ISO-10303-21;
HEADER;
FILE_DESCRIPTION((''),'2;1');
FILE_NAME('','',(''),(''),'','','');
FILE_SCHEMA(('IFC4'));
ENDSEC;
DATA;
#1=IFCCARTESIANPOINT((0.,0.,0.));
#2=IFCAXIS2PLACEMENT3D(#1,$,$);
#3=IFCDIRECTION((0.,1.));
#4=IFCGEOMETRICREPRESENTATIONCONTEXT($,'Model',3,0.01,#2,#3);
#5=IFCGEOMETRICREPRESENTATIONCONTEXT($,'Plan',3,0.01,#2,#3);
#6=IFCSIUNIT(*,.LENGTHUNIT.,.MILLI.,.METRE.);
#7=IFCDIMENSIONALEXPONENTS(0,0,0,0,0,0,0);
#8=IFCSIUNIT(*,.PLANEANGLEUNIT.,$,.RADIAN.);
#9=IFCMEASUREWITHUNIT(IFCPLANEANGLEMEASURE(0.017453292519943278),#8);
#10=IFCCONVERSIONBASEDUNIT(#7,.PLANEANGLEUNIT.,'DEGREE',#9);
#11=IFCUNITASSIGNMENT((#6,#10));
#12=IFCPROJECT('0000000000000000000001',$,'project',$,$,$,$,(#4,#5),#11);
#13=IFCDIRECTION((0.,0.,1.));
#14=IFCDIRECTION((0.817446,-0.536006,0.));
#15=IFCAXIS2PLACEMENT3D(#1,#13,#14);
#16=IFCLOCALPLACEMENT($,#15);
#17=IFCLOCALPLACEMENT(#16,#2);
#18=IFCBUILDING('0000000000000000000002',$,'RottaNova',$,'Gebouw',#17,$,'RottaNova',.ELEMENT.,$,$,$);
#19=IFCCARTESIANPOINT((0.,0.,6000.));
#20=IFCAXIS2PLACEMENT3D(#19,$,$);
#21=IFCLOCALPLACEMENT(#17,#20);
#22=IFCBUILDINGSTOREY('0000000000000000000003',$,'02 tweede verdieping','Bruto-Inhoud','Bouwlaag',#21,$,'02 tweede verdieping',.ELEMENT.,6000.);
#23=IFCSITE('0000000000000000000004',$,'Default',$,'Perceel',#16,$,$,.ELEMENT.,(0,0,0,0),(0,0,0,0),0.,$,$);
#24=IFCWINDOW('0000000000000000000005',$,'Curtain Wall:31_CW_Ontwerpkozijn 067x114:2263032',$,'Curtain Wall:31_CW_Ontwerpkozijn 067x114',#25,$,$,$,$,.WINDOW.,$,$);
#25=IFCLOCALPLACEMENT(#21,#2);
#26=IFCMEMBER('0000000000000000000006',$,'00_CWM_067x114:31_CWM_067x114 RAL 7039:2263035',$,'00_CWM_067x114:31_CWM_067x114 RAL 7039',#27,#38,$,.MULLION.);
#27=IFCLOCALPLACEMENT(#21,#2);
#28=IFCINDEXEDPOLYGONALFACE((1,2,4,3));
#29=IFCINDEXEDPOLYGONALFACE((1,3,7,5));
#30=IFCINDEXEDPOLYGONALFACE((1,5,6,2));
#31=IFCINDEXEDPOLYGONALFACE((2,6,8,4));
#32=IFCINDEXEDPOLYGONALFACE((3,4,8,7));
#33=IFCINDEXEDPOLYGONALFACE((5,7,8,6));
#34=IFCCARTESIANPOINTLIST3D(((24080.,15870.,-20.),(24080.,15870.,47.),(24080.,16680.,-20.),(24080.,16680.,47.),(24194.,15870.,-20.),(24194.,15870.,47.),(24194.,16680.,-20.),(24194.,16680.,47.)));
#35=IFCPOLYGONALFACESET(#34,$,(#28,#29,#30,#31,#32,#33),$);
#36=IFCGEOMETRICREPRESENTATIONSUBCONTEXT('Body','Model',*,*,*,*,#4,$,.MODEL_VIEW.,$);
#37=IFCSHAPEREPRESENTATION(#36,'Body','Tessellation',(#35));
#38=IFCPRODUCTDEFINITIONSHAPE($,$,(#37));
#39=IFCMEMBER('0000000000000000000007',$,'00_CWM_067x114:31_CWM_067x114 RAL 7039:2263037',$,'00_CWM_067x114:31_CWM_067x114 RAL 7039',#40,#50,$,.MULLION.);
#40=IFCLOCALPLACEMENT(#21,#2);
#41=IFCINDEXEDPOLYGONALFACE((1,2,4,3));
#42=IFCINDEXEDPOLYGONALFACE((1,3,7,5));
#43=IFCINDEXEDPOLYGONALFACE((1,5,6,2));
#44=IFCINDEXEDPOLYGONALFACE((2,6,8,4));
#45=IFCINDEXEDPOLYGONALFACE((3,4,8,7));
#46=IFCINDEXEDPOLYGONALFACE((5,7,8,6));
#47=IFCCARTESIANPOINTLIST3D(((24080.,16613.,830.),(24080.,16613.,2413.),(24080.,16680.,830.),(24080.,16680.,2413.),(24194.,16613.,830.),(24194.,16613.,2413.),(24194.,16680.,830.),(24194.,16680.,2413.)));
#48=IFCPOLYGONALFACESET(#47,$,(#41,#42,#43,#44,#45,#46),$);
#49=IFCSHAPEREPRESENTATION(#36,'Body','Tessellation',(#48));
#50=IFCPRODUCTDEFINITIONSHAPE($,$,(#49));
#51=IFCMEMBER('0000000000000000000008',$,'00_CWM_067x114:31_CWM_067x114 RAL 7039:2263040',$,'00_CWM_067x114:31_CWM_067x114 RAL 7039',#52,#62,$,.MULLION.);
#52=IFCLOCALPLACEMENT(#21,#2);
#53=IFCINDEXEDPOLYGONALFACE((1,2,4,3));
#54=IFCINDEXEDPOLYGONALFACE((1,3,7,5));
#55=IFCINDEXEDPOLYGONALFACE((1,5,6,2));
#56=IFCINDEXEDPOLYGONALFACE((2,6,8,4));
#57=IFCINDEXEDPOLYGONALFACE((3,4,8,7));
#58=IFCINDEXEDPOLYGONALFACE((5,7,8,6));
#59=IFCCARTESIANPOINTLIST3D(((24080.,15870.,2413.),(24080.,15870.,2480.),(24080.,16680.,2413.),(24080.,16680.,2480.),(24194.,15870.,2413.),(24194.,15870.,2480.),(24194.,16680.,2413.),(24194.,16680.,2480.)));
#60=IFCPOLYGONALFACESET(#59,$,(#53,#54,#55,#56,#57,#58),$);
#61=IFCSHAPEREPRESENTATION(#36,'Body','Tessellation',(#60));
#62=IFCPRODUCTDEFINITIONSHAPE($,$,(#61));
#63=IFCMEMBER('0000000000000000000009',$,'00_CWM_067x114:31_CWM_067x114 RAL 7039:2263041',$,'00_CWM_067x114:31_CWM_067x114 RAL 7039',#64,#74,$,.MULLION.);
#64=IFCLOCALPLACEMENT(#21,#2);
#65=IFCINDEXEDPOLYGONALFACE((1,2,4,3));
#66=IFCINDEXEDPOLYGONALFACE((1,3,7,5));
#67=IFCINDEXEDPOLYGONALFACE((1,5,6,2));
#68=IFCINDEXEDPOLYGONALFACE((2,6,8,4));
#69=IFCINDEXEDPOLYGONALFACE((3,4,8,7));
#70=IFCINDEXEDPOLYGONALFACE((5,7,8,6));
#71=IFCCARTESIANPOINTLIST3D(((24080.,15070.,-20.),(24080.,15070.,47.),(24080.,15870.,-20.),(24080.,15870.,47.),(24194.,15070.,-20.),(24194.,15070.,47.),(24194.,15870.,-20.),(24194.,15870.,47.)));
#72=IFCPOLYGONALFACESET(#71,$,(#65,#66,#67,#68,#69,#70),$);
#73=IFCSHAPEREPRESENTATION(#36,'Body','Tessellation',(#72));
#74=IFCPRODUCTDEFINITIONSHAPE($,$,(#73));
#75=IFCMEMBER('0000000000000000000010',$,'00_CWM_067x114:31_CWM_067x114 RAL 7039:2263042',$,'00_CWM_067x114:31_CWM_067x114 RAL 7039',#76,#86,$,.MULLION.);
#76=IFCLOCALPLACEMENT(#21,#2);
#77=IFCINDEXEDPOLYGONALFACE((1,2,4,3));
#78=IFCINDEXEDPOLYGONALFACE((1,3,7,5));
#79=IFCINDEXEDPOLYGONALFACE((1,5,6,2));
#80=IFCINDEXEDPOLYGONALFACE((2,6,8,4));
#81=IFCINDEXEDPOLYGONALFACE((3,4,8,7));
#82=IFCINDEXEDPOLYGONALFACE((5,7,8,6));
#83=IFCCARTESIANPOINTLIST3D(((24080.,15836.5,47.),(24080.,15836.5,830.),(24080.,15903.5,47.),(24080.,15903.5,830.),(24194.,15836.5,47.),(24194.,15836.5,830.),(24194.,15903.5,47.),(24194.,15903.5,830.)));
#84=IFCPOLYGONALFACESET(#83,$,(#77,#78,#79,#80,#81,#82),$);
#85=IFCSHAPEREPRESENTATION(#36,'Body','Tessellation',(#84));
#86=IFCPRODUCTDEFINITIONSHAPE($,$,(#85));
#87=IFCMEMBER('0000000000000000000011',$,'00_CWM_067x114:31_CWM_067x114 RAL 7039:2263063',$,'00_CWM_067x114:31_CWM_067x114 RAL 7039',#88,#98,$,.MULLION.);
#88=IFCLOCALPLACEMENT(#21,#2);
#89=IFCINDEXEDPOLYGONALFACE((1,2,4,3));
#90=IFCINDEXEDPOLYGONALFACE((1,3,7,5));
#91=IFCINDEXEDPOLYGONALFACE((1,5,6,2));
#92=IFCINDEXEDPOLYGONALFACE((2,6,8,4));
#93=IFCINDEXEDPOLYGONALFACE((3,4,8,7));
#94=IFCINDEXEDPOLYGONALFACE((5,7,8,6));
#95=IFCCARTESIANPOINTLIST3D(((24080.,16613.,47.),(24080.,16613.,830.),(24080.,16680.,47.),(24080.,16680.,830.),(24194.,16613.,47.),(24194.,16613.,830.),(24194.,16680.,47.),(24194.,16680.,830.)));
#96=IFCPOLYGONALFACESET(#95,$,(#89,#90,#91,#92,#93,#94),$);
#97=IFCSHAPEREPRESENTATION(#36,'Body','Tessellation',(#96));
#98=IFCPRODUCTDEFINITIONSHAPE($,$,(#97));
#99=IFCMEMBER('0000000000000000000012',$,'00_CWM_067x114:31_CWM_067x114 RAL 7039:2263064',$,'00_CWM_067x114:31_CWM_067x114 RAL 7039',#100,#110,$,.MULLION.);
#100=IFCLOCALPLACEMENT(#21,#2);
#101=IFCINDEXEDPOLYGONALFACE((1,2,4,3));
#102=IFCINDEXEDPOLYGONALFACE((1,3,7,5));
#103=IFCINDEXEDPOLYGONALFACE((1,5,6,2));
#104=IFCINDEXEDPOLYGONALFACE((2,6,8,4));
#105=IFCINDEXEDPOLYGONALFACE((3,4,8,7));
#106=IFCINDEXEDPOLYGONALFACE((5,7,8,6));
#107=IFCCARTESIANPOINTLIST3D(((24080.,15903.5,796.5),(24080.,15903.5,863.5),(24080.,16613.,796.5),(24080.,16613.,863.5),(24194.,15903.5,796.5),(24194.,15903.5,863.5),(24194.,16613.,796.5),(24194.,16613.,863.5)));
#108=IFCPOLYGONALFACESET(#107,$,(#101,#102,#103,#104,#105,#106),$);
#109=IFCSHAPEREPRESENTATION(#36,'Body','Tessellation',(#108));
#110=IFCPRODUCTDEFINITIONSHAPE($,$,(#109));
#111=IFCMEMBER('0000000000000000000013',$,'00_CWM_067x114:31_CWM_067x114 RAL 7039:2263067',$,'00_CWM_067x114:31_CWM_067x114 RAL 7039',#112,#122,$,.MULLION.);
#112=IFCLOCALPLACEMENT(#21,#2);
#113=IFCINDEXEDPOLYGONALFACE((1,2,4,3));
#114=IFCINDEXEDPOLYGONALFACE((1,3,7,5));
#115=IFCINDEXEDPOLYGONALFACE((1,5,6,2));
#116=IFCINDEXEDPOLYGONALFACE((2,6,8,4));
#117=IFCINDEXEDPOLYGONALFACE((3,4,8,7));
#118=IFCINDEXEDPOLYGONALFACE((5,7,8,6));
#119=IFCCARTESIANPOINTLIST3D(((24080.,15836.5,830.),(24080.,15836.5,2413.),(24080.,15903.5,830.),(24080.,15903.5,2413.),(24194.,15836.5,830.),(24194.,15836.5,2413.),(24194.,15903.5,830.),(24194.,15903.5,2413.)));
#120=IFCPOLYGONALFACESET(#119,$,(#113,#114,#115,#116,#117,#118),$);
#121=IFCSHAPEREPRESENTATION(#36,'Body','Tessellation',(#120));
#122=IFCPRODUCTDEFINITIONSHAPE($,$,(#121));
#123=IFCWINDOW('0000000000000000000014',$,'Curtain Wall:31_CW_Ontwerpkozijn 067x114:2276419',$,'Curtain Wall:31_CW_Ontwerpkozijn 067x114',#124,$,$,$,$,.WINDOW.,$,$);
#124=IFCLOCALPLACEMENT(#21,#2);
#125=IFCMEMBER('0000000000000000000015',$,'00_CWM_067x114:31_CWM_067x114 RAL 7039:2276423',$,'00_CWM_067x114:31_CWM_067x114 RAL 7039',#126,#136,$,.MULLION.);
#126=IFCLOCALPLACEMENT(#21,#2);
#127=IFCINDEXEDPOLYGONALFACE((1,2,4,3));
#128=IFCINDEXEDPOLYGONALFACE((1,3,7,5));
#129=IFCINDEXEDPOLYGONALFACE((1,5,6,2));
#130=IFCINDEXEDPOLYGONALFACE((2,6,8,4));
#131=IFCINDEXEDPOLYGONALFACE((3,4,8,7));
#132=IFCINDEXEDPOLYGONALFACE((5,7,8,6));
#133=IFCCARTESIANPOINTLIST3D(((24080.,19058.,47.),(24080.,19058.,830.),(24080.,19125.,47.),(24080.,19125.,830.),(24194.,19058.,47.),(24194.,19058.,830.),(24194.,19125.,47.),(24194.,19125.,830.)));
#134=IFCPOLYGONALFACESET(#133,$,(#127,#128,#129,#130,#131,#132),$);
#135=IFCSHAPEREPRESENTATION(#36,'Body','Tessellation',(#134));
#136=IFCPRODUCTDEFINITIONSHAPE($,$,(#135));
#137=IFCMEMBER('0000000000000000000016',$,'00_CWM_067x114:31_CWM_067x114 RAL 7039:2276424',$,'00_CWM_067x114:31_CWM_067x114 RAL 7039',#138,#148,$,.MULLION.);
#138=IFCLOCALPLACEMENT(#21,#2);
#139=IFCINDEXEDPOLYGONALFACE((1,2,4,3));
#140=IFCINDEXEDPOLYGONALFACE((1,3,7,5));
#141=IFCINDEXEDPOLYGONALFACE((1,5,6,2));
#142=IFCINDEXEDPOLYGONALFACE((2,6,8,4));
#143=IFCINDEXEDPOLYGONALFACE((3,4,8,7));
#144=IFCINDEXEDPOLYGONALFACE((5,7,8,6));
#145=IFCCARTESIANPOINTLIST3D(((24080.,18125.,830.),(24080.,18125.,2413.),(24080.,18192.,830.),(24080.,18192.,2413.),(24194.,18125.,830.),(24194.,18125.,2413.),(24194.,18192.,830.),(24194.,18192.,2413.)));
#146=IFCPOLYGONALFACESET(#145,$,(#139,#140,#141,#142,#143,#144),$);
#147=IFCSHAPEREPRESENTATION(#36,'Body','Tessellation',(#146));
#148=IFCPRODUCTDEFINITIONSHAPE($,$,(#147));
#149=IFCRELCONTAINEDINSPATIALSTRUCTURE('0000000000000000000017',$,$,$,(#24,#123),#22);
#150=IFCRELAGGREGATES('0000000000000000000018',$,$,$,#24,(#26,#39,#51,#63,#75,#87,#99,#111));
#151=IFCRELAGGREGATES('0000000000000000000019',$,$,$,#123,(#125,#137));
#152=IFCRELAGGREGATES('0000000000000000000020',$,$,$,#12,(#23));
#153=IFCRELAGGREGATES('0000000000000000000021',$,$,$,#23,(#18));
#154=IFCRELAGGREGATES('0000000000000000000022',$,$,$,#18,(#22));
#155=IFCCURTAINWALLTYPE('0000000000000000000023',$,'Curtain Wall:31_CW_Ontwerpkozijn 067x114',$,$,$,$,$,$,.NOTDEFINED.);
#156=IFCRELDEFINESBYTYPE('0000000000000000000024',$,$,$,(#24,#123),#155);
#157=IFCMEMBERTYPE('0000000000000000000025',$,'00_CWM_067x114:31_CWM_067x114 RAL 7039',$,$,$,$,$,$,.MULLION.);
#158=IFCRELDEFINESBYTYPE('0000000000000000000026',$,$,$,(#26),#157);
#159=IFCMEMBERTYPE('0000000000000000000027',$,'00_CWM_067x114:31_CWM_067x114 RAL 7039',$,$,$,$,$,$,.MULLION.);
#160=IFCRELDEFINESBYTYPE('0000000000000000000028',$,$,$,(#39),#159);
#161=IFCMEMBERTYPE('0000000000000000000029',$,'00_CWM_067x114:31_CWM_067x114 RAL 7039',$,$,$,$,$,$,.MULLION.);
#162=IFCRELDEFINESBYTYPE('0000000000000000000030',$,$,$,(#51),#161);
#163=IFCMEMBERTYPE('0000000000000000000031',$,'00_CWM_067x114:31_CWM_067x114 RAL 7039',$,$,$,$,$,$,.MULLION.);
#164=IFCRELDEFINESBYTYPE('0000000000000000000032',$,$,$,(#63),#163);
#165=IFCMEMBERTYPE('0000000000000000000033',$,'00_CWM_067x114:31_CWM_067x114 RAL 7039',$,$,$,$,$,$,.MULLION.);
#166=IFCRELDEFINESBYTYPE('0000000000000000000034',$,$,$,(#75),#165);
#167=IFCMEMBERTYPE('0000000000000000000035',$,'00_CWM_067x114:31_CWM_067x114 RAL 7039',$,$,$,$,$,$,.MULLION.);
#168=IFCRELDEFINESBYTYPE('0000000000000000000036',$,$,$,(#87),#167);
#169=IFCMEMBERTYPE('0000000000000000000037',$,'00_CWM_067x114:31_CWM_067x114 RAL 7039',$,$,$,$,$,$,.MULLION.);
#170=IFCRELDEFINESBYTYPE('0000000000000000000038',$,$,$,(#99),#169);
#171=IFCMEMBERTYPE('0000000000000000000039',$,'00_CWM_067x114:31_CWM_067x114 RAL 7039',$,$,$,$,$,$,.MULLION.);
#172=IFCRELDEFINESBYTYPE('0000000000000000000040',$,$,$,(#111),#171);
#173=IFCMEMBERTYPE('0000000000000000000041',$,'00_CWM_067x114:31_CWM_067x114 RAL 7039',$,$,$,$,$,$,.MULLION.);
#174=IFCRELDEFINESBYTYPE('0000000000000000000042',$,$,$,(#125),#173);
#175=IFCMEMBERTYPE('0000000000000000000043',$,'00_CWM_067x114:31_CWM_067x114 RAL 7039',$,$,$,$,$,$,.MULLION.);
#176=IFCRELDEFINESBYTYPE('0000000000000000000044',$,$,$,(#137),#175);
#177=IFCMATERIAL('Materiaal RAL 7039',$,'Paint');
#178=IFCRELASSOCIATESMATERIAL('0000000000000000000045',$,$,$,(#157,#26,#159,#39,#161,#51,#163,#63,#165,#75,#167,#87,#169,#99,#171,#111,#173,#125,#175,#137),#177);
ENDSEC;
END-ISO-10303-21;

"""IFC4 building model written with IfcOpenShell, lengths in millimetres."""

from ifc_helpers import new_model, entity, si_unit, converted_unit, direction, frame, origin, place, context, subcontext, project, spatial, indexed_curve, outline, extrude, source, transform, mapped, material, type_object, type_shapes, element, aggregate, save


model = new_model("IFC4")

# Units and contexts
model_context = context("Model", 3, precision=0.01, world=origin(), true_north=direction((0.0, 1.0)))
plan_context = context("Plan", 3, precision=0.01, world=origin(), true_north=direction((0.0, 1.0)))
body_context = subcontext(model_context, "Body", "Model", "MODEL_VIEW")
ifc_project = project(units=[si_unit("LENGTHUNIT", "METRE", prefix="MILLI"), converted_unit("PLANEANGLEUNIT", "DEGREE", entity("IfcPlaneAngleMeasure", 0.017453292519943278), si_unit("PLANEANGLEUNIT", "RADIAN"), dimensions=[0, 0, 0, 0, 0, 0, 0])], contexts=[model_context, plan_context])

# Site, building, storey
site_placement = place(None, frame((0.0, 0.0, 0.0), z_axis=(0.0, 0.0, 1.0), x_axis=(0.817446, -0.536006, 0.0)))
site = spatial("IfcSite", under=ifc_project, at=site_placement, Name="Default", ObjectType="Perceel", CompositionType="ELEMENT", RefLatitude=(0, 0, 0, 0), RefLongitude=(0, 0, 0, 0), RefElevation=0.0)
building_placement = place(site_placement, origin())
building = spatial("IfcBuilding", under=site, at=building_placement, Name="RottaNova", ObjectType="Gebouw", LongName="RottaNova", CompositionType="ELEMENT")
storey_placement = place(building_placement, frame((0.0, 0.0, 6000.0)))
storey = spatial("IfcBuildingStorey", under=building, at=storey_placement, Name="02 tweede verdieping", Description="Bruto-Inhoud", ObjectType="Bouwlaag", LongName="02 tweede verdieping", CompositionType="ELEMENT", Elevation=6000.0)

# Windows, members
curtain_wall_type = type_object("IfcCurtainWallType", Name="Curtain Wall:31_CW_Ontwerpkozijn 067x114", PredefinedType="NOTDEFINED")
window_1_placement = place(storey_placement, frame((0.0, 0.0, -6000.0)))
window_1 = element("IfcWindow", 1, at=window_1_placement, inside=storey, type_object=curtain_wall_type, Name="Curtain Wall:31_CW_Ontwerpkozijn 067x114:2263032", ObjectType="Curtain Wall:31_CW_Ontwerpkozijn 067x114", PredefinedType="WINDOW")
ifc_material_1 = material(Name="Materiaal RAL 7039", Category="Paint")
member_type_1 = type_object("IfcMemberType", Name="00_CWM_067x114:31_CWM_067x114 RAL 7039", PredefinedType="MULLION", material=ifc_material_1)
shared_shape_1 = source(origin(), body_context, "Body", "SweptSolid", [
    extrude(outline(indexed_curve([(-33.5, -57.0), (33.5, -57.0), (33.5, 57.0), (-33.5, 57.0), (-33.5, -57.0)], self_intersect=False)), frame((-33.5, -57.0, -810.0), z_axis=(0.0, 0.0, 1.0), x_axis=(-1.0, 0.0, 0.0)), (0.0, 0.0, 1.0), 810.0),
])
type_shapes(member_type_1, [shared_shape_1])
member_1_placement = place(window_1_placement, frame((24080.0, 16680.0, 5980.0), z_axis=(0.0, 1.0, 0.0), x_axis=(0.0, 0.0, -1.0)))
member_1 = element("IfcMember", 2, at=member_1_placement, type_object=member_type_1, material=ifc_material_1, Name="00_CWM_067x114:31_CWM_067x114 RAL 7039:2263035", ObjectType="00_CWM_067x114:31_CWM_067x114 RAL 7039", PredefinedType="MULLION", context=body_context, shape_type="MappedRepresentation", body=[
    mapped(shared_shape_1, transform((0.0, 0.0, 0.0), scale=1.0)),
])
member_type_2 = type_object("IfcMemberType", Name="00_CWM_067x114:31_CWM_067x114 RAL 7039", PredefinedType="MULLION", material=ifc_material_1)
shared_shape_2 = source(origin(), body_context, "Body", "SweptSolid", [
    extrude(outline(indexed_curve([(-33.5, -57.0), (33.5, -57.0), (33.5, 57.0), (-33.5, 57.0), (-33.5, -57.0)], self_intersect=False)), frame((-33.5, -57.0, -1583.0), z_axis=(0.0, 0.0, 1.0), x_axis=(-1.0, 0.0, 0.0)), (0.0, 0.0, 1.0), 1583.0),
])
type_shapes(member_type_2, [shared_shape_2])
member_2_placement = place(window_1_placement, frame((24080.0, 16680.0, 8413.0), z_axis=(0.0, 0.0, 1.0), x_axis=(0.0, 1.0, 0.0)))
member_2 = element("IfcMember", 3, at=member_2_placement, type_object=member_type_2, material=ifc_material_1, Name="00_CWM_067x114:31_CWM_067x114 RAL 7039:2263037", ObjectType="00_CWM_067x114:31_CWM_067x114 RAL 7039", PredefinedType="MULLION", context=body_context, shape_type="MappedRepresentation", body=[
    mapped(shared_shape_2, transform((0.0, 0.0, 0.0), scale=1.0)),
])
member_type_3 = type_object("IfcMemberType", Name="00_CWM_067x114:31_CWM_067x114 RAL 7039", PredefinedType="MULLION", material=ifc_material_1)
shared_shape_3 = source(origin(), body_context, "Body", "SweptSolid", [
    extrude(outline(indexed_curve([(-33.5, -57.0), (33.5, -57.0), (33.5, 57.0), (-33.5, 57.0), (-33.5, -57.0)], self_intersect=False)), frame((-33.5, -57.0, -810.0), z_axis=(0.0, 0.0, 1.0), x_axis=(-1.0, 0.0, 0.0)), (0.0, 0.0, 1.0), 810.0),
])
type_shapes(member_type_3, [shared_shape_3])
member_3_placement = place(window_1_placement, frame((24080.0, 15870.0, 8480.0), z_axis=(0.0, -1.0, 0.0), x_axis=(0.0, 0.0, 1.0)))
member_3 = element("IfcMember", 4, at=member_3_placement, type_object=member_type_3, material=ifc_material_1, Name="00_CWM_067x114:31_CWM_067x114 RAL 7039:2263040", ObjectType="00_CWM_067x114:31_CWM_067x114 RAL 7039", PredefinedType="MULLION", context=body_context, shape_type="MappedRepresentation", body=[
    mapped(shared_shape_3, transform((0.0, 0.0, 0.0), scale=1.0)),
])
member_type_4 = type_object("IfcMemberType", Name="00_CWM_067x114:31_CWM_067x114 RAL 7039", PredefinedType="MULLION", material=ifc_material_1)
shared_shape_4 = source(origin(), body_context, "Body", "SweptSolid", [
    extrude(outline(indexed_curve([(-33.5, -57.0), (33.5, -57.0), (33.5, 57.0), (-33.5, 57.0), (-33.5, -57.0)], self_intersect=False)), frame((-33.5, -57.0, -800.0), z_axis=(0.0, 0.0, 1.0), x_axis=(-1.0, 0.0, 0.0)), (0.0, 0.0, 1.0), 800.0),
])
type_shapes(member_type_4, [shared_shape_4])
member_4_placement = place(window_1_placement, frame((24080.0, 15870.0, 5980.0), z_axis=(0.0, 1.0, 0.0), x_axis=(0.0, 0.0, -1.0)))
member_4 = element("IfcMember", 5, at=member_4_placement, type_object=member_type_4, material=ifc_material_1, Name="00_CWM_067x114:31_CWM_067x114 RAL 7039:2263041", ObjectType="00_CWM_067x114:31_CWM_067x114 RAL 7039", PredefinedType="MULLION", context=body_context, shape_type="MappedRepresentation", body=[
    mapped(shared_shape_4, transform((0.0, 0.0, 0.0), scale=1.0)),
])
member_type_5 = type_object("IfcMemberType", Name="00_CWM_067x114:31_CWM_067x114 RAL 7039", PredefinedType="MULLION", material=ifc_material_1)
shared_shape_5 = source(origin(), body_context, "Body", "SweptSolid", [
    extrude(outline(indexed_curve([(-33.5, -57.0), (33.5, -57.0), (33.5, 57.0), (-33.5, 57.0), (-33.5, -57.0)], self_intersect=False)), frame((0.0, -57.0, -783.0), z_axis=(0.0, 0.0, 1.0), x_axis=(-1.0, 0.0, 0.0)), (0.0, 0.0, 1.0), 783.0),
])
type_shapes(member_type_5, [shared_shape_5])
member_5_placement = place(window_1_placement, frame((24080.0, 15870.0, 6047.0), z_axis=(0.0, 0.0, -1.0), x_axis=(0.0, -1.0, 0.0)))
member_5 = element("IfcMember", 6, at=member_5_placement, type_object=member_type_5, material=ifc_material_1, Name="00_CWM_067x114:31_CWM_067x114 RAL 7039:2263042", ObjectType="00_CWM_067x114:31_CWM_067x114 RAL 7039", PredefinedType="MULLION", context=body_context, shape_type="MappedRepresentation", body=[
    mapped(shared_shape_5, transform((0.0, 0.0, 0.0), scale=1.0)),
])
member_type_6 = type_object("IfcMemberType", Name="00_CWM_067x114:31_CWM_067x114 RAL 7039", PredefinedType="MULLION", material=ifc_material_1)
shared_shape_6 = source(origin(), body_context, "Body", "SweptSolid", [
    extrude(outline(indexed_curve([(-33.5, -57.0), (33.5, -57.0), (33.5, 57.0), (-33.5, 57.0), (-33.5, -57.0)], self_intersect=False)), frame((-33.5, -57.0, -783.0), z_axis=(0.0, 0.0, 1.0), x_axis=(-1.0, 0.0, 0.0)), (0.0, 0.0, 1.0), 783.0),
])
type_shapes(member_type_6, [shared_shape_6])
member_6_placement = place(window_1_placement, frame((24080.0, 16680.0, 6830.0), z_axis=(0.0, 0.0, 1.0), x_axis=(0.0, 1.0, 0.0)))
member_6 = element("IfcMember", 7, at=member_6_placement, type_object=member_type_6, material=ifc_material_1, Name="00_CWM_067x114:31_CWM_067x114 RAL 7039:2263063", ObjectType="00_CWM_067x114:31_CWM_067x114 RAL 7039", PredefinedType="MULLION", context=body_context, shape_type="MappedRepresentation", body=[
    mapped(shared_shape_6, transform((0.0, 0.0, 0.0), scale=1.0)),
])
member_type_7 = type_object("IfcMemberType", Name="00_CWM_067x114:31_CWM_067x114 RAL 7039", PredefinedType="MULLION", material=ifc_material_1)
shared_shape_7 = source(origin(), body_context, "Body", "SweptSolid", [
    extrude(outline(indexed_curve([(-33.5, -57.0), (33.5, -57.0), (33.5, 57.0), (-33.5, 57.0), (-33.5, -57.0)], self_intersect=False)), frame((0.0, -57.0, -709.5), z_axis=(0.0, 0.0, 1.0), x_axis=(-1.0, 0.0, 0.0)), (0.0, 0.0, 1.0), 709.5),
])
type_shapes(member_type_7, [shared_shape_7])
member_7_placement = place(window_1_placement, frame((24080.0, 15903.5, 6830.0), z_axis=(0.0, -1.0, 0.0), x_axis=(0.0, 0.0, 1.0)))
member_7 = element("IfcMember", 8, at=member_7_placement, type_object=member_type_7, material=ifc_material_1, Name="00_CWM_067x114:31_CWM_067x114 RAL 7039:2263064", ObjectType="00_CWM_067x114:31_CWM_067x114 RAL 7039", PredefinedType="MULLION", context=body_context, shape_type="MappedRepresentation", body=[
    mapped(shared_shape_7, transform((0.0, 0.0, 0.0), scale=1.0)),
])
member_type_8 = type_object("IfcMemberType", Name="00_CWM_067x114:31_CWM_067x114 RAL 7039", PredefinedType="MULLION", material=ifc_material_1)
shared_shape_8 = source(origin(), body_context, "Body", "SweptSolid", [
    extrude(outline(indexed_curve([(-33.5, -57.0), (33.5, -57.0), (33.5, 57.0), (-33.5, 57.0), (-33.5, -57.0)], self_intersect=False)), frame((0.0, -57.0, -1583.0), z_axis=(0.0, 0.0, 1.0), x_axis=(-1.0, 0.0, 0.0)), (0.0, 0.0, 1.0), 1583.0),
])
type_shapes(member_type_8, [shared_shape_8])
member_8_placement = place(window_1_placement, frame((24080.0, 15870.0, 6830.0), z_axis=(0.0, 0.0, -1.0), x_axis=(0.0, -1.0, 0.0)))
member_8 = element("IfcMember", 9, at=member_8_placement, type_object=member_type_8, material=ifc_material_1, Name="00_CWM_067x114:31_CWM_067x114 RAL 7039:2263067", ObjectType="00_CWM_067x114:31_CWM_067x114 RAL 7039", PredefinedType="MULLION", context=body_context, shape_type="MappedRepresentation", body=[
    mapped(shared_shape_8, transform((0.0, 0.0, 0.0), scale=1.0)),
])
window_2_placement = place(storey_placement, frame((0.0, 0.0, -6000.0)))
window_2 = element("IfcWindow", 10, at=window_2_placement, inside=storey, type_object=curtain_wall_type, Name="Curtain Wall:31_CW_Ontwerpkozijn 067x114:2276419", ObjectType="Curtain Wall:31_CW_Ontwerpkozijn 067x114", PredefinedType="WINDOW")
member_type_9 = type_object("IfcMemberType", Name="00_CWM_067x114:31_CWM_067x114 RAL 7039", PredefinedType="MULLION", material=ifc_material_1)
shared_shape_9 = source(origin(), body_context, "Body", "SweptSolid", [
    extrude(outline(indexed_curve([(-33.5, -57.0), (33.5, -57.0), (33.5, 57.0), (-33.5, 57.0), (-33.5, -57.0)], self_intersect=False)), frame((-33.5, 57.0, -783.0), z_axis=(0.0, 0.0, 1.0), x_axis=(-1.0, 0.0, 0.0)), (0.0, 0.0, 1.0), 783.0),
])
type_shapes(member_type_9, [shared_shape_9])
member_9_placement = place(window_2_placement, frame((24080.0, 19125.0, 6047.0), z_axis=(0.0, 0.0, -1.0), x_axis=(0.0, 1.0, 0.0)))
member_9 = element("IfcMember", 11, at=member_9_placement, type_object=member_type_9, material=ifc_material_1, Name="00_CWM_067x114:31_CWM_067x114 RAL 7039:2276423", ObjectType="00_CWM_067x114:31_CWM_067x114 RAL 7039", PredefinedType="MULLION", context=body_context, shape_type="MappedRepresentation", body=[
    mapped(shared_shape_9, transform((0.0, 0.0, 0.0), scale=1.0)),
])
member_type_10 = type_object("IfcMemberType", Name="00_CWM_067x114:31_CWM_067x114 RAL 7039", PredefinedType="MULLION", material=ifc_material_1)
shared_shape_10 = source(origin(), body_context, "Body", "SweptSolid", [
    extrude(outline(indexed_curve([(-33.5, -57.0), (33.5, -57.0), (33.5, 57.0), (-33.5, 57.0), (-33.5, -57.0)], self_intersect=False)), frame((-33.5, 57.0, -1583.0), z_axis=(0.0, 0.0, 1.0), x_axis=(-1.0, 0.0, 0.0)), (0.0, 0.0, 1.0), 1583.0),
])
type_shapes(member_type_10, [shared_shape_10])
member_10_placement = place(window_2_placement, frame((24080.0, 18125.0, 8413.0), z_axis=(0.0, 0.0, 1.0), x_axis=(0.0, -1.0, 0.0)))
member_10 = element("IfcMember", 12, at=member_10_placement, type_object=member_type_10, material=ifc_material_1, Name="00_CWM_067x114:31_CWM_067x114 RAL 7039:2276424", ObjectType="00_CWM_067x114:31_CWM_067x114 RAL 7039", PredefinedType="MULLION", context=body_context, shape_type="MappedRepresentation", body=[
    mapped(shared_shape_10, transform((0.0, 0.0, 0.0), scale=1.0)),
])

aggregate(window_1, [member_1, member_2, member_3, member_4, member_5, member_6, member_7, member_8])
aggregate(window_2, [member_9, member_10])

save(model, "model.ifc")
